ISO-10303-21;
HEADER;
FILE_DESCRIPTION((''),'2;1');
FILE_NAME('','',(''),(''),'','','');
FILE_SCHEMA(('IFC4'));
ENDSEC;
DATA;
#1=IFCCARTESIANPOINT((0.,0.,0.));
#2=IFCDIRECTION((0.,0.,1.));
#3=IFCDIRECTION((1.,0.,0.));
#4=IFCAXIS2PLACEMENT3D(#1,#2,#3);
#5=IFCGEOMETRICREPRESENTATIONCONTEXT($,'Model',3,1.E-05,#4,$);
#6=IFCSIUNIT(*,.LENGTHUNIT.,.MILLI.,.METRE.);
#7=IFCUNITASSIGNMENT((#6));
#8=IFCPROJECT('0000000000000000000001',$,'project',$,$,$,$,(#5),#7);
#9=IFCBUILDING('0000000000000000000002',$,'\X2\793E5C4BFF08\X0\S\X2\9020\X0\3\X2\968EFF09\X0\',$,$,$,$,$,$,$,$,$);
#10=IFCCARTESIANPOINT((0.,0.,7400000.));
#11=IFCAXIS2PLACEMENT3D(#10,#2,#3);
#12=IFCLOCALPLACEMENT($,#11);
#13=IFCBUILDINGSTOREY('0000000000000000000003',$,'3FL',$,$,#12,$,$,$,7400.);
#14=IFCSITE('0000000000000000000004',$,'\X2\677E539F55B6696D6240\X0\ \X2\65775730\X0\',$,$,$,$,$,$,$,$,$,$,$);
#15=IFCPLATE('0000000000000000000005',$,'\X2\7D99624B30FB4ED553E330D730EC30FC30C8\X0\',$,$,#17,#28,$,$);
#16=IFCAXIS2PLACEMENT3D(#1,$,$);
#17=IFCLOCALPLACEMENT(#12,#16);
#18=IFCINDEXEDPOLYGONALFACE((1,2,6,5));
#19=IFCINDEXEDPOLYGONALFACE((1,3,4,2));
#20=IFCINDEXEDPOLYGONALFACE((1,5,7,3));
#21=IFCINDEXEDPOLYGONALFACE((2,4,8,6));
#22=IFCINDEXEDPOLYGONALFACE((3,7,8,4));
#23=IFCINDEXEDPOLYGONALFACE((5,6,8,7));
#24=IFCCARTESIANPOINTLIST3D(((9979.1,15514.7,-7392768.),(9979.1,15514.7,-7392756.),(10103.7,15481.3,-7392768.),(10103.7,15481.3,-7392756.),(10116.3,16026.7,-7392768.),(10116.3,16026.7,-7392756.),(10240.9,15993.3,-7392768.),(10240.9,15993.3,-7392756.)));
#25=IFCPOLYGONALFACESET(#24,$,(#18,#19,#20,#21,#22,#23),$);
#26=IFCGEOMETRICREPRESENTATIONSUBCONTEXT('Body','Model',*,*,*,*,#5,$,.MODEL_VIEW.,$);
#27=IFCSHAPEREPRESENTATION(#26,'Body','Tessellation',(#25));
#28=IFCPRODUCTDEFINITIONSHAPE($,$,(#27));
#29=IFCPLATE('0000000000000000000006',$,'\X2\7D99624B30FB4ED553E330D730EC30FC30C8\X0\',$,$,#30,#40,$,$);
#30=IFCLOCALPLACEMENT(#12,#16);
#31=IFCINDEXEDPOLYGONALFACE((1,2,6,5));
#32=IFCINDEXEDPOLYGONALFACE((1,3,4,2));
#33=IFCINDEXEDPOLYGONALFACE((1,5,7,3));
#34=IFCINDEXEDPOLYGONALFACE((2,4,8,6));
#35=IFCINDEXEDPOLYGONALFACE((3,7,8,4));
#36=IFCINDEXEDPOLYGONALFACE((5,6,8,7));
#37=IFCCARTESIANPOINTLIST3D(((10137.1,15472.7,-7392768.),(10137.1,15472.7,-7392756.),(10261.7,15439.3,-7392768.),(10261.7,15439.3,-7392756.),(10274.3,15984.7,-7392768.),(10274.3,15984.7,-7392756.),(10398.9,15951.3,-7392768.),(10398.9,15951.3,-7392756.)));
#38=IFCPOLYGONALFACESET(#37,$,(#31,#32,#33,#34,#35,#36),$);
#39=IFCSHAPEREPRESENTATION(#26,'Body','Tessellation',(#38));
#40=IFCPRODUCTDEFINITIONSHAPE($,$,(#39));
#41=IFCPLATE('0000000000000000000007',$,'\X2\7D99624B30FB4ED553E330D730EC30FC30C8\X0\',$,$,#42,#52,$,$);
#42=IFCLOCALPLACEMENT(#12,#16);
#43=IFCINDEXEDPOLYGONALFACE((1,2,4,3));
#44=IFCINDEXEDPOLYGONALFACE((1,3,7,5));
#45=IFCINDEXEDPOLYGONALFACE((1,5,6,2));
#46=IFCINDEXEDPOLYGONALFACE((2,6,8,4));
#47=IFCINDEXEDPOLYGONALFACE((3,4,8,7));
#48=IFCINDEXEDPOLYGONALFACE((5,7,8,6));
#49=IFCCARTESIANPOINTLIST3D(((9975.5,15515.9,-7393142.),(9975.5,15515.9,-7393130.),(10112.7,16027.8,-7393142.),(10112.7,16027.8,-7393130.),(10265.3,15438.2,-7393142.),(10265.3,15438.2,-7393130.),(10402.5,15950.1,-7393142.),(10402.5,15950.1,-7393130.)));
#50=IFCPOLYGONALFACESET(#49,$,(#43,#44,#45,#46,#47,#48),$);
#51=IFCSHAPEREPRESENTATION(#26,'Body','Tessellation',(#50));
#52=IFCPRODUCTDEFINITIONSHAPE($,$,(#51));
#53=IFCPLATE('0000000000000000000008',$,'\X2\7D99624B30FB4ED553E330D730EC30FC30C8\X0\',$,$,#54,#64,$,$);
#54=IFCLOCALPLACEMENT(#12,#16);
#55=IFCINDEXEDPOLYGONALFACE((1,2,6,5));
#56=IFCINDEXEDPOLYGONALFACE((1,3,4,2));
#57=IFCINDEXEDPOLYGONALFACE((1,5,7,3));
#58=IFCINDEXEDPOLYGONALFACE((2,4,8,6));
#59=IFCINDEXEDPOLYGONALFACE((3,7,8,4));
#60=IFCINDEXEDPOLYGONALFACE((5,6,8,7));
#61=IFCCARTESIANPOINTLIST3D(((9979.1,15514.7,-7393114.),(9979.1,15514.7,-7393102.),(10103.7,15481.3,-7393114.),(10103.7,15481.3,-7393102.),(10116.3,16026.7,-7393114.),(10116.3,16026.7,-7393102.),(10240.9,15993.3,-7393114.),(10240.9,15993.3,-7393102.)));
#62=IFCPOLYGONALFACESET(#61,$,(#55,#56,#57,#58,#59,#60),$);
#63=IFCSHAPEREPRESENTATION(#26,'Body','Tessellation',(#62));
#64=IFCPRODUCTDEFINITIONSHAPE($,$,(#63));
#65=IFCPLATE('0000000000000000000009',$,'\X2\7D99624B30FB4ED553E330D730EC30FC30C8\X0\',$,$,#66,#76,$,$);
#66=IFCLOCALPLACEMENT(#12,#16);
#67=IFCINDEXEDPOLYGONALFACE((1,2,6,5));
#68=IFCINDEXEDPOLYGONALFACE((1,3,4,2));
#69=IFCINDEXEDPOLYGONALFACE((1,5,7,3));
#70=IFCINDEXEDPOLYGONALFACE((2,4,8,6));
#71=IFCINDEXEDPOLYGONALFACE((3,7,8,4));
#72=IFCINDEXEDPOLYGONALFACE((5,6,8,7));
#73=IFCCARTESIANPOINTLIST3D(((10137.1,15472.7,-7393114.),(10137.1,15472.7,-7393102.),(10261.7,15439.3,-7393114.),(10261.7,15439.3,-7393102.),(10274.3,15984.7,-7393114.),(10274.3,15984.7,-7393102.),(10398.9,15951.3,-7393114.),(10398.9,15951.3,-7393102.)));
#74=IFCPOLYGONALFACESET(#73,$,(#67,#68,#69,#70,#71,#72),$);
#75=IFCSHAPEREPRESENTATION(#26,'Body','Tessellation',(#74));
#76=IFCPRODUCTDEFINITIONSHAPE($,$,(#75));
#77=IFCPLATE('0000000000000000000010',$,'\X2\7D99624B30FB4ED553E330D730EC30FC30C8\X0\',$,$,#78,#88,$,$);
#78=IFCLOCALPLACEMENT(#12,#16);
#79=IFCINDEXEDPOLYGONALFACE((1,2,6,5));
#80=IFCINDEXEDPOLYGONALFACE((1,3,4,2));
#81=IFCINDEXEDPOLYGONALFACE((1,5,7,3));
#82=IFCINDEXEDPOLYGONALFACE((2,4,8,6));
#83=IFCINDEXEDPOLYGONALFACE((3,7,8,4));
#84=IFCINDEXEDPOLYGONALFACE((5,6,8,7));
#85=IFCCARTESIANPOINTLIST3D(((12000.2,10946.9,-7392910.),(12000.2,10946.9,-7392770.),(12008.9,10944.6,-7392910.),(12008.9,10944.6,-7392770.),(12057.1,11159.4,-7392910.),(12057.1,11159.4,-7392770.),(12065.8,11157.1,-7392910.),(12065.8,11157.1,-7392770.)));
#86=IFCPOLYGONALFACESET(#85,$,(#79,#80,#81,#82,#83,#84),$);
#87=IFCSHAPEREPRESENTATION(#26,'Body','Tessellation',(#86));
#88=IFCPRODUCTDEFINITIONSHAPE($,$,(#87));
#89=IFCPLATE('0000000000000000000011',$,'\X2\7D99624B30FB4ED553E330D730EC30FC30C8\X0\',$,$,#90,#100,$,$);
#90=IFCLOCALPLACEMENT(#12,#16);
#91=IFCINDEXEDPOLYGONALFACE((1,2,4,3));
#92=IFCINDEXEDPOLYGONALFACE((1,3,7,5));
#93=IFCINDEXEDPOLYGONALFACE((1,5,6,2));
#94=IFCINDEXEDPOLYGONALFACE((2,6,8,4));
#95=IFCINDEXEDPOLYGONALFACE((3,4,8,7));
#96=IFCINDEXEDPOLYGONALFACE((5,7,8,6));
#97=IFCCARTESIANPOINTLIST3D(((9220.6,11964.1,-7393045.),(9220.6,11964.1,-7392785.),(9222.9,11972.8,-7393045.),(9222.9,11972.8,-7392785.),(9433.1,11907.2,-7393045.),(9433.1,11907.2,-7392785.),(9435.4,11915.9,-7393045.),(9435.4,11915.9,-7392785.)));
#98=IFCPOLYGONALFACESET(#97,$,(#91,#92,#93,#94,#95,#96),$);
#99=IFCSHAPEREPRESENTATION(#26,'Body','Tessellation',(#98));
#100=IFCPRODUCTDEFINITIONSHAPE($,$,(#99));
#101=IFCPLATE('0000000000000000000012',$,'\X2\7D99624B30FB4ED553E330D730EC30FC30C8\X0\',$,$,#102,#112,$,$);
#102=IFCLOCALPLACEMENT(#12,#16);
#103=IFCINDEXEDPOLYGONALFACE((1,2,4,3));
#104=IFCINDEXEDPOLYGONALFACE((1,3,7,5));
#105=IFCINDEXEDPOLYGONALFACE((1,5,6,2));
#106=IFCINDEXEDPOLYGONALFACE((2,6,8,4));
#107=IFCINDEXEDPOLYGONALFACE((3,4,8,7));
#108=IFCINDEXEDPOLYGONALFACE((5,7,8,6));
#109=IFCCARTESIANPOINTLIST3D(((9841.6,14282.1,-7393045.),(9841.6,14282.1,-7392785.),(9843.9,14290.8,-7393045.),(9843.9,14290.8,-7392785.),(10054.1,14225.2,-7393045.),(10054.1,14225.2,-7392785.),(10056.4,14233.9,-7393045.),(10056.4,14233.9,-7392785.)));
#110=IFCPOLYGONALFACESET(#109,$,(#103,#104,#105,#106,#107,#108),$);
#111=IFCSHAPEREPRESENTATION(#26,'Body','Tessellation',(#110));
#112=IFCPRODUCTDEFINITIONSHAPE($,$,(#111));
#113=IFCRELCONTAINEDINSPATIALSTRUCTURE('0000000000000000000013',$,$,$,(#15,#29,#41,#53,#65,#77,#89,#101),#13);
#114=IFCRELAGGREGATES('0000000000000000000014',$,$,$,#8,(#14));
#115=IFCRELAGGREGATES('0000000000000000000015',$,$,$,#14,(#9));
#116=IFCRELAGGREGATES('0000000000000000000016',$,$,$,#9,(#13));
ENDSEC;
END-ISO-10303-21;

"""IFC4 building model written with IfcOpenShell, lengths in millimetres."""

from ifc_helpers import new_model, si_unit, frame, origin, origin_with_axes, place, context, subcontext, project, spatial, rectangle, extrude, element, save


model = new_model("IFC4")

# Units and contexts
model_context = context("Model", 3, precision=1e-05, world=origin_with_axes())
body_context = subcontext(model_context, "Body", "Model", "MODEL_VIEW")
ifc_project = project(units=[si_unit("LENGTHUNIT", "METRE", prefix="MILLI")], contexts=[model_context])

# Site, building, storey
site = spatial("IfcSite", under=ifc_project, Name="松原営業所 敷地")
building = spatial("IfcBuilding", under=site, Name="社屋（S造3階）")
storey_placement = place(None, frame((0.0, 0.0, 7400000.0), z_axis=(0.0, 0.0, 1.0), x_axis=(1.0, 0.0, 0.0)))
storey = spatial("IfcBuildingStorey", under=building, at=storey_placement, Name="3FL", Elevation=7400.0)

# Plates
for number, where, z_axis, x_axis, name in (
    (1, (10041.4, 15498.0, -7392762.0), (0.258819, 0.965926, 0.0), (-0.965926, 0.258819, 0.0), "継手・仕口プレート"),
    (2, (10199.4, 15456.0, -7392762.0), (0.258819, 0.965926, 0.0), (-0.965926, 0.258819, 0.0), "継手・仕口プレート"),
):
    element("IfcPlate", number, at=place(storey_placement, frame(where, z_axis=z_axis, x_axis=x_axis)), inside=storey, Name=name, context=body_context, shape_type="SweptSolid", body=[
        extrude(rectangle(XDim=129.0, YDim=12.0), origin(), (0.0, 0.0, 1.0), 530.0),
    ])
plate_1_placement = place(storey_placement, frame((10120.4, 15477.0, -7393136.0), z_axis=(0.258819, 0.965926, 0.0), x_axis=(-0.965926, 0.258819, 0.0)))
element("IfcPlate", 3, at=plate_1_placement, inside=storey, Name="継手・仕口プレート", context=body_context, shape_type="SweptSolid", body=[
    extrude(rectangle(XDim=300.0, YDim=12.0), origin(), (0.0, 0.0, 1.0), 530.0),
])
for number, where, z_axis, x_axis, name in (
    (4, (10041.4, 15498.0, -7393108.0), (0.258819, 0.965926, 0.0), (-0.965926, 0.258819, 0.0), "継手・仕口プレート"),
    (5, (10199.4, 15456.0, -7393108.0), (0.258819, 0.965926, 0.0), (-0.965926, 0.258819, 0.0), "継手・仕口プレート"),
):
    element("IfcPlate", number, at=place(storey_placement, frame(where, z_axis=z_axis, x_axis=x_axis)), inside=storey, Name=name, context=body_context, shape_type="SweptSolid", body=[
        extrude(rectangle(XDim=129.0, YDim=12.0), origin(), (0.0, 0.0, 1.0), 530.0),
    ])
plate_2_placement = place(storey_placement, frame((12004.5, 10945.7, -7392840.0), z_axis=(0.258819, 0.965926, 0.0), x_axis=(-0.965926, 0.258819, 0.0)))
element("IfcPlate", 6, at=plate_2_placement, inside=storey, Name="継手・仕口プレート", context=body_context, shape_type="SweptSolid", body=[
    extrude(rectangle(XDim=9.0, YDim=140.0), origin(), (0.0, 0.0, 1.0), 220.0),
])
for number, where, z_axis, x_axis, name in (
    (7, (9221.7, 11968.5, -7392915.0), (0.965926, -0.258819, 0.0), (0.258819, 0.965926, 0.0), "継手・仕口プレート"),
    (8, (9842.7, 14286.5, -7392915.0), (0.965926, -0.258819, 0.0), (0.258819, 0.965926, 0.0), "継手・仕口プレート"),
):
    element("IfcPlate", number, at=place(storey_placement, frame(where, z_axis=z_axis, x_axis=x_axis)), inside=storey, Name=name, context=body_context, shape_type="SweptSolid", body=[
        extrude(rectangle(XDim=9.0, YDim=260.0), origin(), (0.0, 0.0, 1.0), 220.0),
    ])

save(model, "model.ifc")
